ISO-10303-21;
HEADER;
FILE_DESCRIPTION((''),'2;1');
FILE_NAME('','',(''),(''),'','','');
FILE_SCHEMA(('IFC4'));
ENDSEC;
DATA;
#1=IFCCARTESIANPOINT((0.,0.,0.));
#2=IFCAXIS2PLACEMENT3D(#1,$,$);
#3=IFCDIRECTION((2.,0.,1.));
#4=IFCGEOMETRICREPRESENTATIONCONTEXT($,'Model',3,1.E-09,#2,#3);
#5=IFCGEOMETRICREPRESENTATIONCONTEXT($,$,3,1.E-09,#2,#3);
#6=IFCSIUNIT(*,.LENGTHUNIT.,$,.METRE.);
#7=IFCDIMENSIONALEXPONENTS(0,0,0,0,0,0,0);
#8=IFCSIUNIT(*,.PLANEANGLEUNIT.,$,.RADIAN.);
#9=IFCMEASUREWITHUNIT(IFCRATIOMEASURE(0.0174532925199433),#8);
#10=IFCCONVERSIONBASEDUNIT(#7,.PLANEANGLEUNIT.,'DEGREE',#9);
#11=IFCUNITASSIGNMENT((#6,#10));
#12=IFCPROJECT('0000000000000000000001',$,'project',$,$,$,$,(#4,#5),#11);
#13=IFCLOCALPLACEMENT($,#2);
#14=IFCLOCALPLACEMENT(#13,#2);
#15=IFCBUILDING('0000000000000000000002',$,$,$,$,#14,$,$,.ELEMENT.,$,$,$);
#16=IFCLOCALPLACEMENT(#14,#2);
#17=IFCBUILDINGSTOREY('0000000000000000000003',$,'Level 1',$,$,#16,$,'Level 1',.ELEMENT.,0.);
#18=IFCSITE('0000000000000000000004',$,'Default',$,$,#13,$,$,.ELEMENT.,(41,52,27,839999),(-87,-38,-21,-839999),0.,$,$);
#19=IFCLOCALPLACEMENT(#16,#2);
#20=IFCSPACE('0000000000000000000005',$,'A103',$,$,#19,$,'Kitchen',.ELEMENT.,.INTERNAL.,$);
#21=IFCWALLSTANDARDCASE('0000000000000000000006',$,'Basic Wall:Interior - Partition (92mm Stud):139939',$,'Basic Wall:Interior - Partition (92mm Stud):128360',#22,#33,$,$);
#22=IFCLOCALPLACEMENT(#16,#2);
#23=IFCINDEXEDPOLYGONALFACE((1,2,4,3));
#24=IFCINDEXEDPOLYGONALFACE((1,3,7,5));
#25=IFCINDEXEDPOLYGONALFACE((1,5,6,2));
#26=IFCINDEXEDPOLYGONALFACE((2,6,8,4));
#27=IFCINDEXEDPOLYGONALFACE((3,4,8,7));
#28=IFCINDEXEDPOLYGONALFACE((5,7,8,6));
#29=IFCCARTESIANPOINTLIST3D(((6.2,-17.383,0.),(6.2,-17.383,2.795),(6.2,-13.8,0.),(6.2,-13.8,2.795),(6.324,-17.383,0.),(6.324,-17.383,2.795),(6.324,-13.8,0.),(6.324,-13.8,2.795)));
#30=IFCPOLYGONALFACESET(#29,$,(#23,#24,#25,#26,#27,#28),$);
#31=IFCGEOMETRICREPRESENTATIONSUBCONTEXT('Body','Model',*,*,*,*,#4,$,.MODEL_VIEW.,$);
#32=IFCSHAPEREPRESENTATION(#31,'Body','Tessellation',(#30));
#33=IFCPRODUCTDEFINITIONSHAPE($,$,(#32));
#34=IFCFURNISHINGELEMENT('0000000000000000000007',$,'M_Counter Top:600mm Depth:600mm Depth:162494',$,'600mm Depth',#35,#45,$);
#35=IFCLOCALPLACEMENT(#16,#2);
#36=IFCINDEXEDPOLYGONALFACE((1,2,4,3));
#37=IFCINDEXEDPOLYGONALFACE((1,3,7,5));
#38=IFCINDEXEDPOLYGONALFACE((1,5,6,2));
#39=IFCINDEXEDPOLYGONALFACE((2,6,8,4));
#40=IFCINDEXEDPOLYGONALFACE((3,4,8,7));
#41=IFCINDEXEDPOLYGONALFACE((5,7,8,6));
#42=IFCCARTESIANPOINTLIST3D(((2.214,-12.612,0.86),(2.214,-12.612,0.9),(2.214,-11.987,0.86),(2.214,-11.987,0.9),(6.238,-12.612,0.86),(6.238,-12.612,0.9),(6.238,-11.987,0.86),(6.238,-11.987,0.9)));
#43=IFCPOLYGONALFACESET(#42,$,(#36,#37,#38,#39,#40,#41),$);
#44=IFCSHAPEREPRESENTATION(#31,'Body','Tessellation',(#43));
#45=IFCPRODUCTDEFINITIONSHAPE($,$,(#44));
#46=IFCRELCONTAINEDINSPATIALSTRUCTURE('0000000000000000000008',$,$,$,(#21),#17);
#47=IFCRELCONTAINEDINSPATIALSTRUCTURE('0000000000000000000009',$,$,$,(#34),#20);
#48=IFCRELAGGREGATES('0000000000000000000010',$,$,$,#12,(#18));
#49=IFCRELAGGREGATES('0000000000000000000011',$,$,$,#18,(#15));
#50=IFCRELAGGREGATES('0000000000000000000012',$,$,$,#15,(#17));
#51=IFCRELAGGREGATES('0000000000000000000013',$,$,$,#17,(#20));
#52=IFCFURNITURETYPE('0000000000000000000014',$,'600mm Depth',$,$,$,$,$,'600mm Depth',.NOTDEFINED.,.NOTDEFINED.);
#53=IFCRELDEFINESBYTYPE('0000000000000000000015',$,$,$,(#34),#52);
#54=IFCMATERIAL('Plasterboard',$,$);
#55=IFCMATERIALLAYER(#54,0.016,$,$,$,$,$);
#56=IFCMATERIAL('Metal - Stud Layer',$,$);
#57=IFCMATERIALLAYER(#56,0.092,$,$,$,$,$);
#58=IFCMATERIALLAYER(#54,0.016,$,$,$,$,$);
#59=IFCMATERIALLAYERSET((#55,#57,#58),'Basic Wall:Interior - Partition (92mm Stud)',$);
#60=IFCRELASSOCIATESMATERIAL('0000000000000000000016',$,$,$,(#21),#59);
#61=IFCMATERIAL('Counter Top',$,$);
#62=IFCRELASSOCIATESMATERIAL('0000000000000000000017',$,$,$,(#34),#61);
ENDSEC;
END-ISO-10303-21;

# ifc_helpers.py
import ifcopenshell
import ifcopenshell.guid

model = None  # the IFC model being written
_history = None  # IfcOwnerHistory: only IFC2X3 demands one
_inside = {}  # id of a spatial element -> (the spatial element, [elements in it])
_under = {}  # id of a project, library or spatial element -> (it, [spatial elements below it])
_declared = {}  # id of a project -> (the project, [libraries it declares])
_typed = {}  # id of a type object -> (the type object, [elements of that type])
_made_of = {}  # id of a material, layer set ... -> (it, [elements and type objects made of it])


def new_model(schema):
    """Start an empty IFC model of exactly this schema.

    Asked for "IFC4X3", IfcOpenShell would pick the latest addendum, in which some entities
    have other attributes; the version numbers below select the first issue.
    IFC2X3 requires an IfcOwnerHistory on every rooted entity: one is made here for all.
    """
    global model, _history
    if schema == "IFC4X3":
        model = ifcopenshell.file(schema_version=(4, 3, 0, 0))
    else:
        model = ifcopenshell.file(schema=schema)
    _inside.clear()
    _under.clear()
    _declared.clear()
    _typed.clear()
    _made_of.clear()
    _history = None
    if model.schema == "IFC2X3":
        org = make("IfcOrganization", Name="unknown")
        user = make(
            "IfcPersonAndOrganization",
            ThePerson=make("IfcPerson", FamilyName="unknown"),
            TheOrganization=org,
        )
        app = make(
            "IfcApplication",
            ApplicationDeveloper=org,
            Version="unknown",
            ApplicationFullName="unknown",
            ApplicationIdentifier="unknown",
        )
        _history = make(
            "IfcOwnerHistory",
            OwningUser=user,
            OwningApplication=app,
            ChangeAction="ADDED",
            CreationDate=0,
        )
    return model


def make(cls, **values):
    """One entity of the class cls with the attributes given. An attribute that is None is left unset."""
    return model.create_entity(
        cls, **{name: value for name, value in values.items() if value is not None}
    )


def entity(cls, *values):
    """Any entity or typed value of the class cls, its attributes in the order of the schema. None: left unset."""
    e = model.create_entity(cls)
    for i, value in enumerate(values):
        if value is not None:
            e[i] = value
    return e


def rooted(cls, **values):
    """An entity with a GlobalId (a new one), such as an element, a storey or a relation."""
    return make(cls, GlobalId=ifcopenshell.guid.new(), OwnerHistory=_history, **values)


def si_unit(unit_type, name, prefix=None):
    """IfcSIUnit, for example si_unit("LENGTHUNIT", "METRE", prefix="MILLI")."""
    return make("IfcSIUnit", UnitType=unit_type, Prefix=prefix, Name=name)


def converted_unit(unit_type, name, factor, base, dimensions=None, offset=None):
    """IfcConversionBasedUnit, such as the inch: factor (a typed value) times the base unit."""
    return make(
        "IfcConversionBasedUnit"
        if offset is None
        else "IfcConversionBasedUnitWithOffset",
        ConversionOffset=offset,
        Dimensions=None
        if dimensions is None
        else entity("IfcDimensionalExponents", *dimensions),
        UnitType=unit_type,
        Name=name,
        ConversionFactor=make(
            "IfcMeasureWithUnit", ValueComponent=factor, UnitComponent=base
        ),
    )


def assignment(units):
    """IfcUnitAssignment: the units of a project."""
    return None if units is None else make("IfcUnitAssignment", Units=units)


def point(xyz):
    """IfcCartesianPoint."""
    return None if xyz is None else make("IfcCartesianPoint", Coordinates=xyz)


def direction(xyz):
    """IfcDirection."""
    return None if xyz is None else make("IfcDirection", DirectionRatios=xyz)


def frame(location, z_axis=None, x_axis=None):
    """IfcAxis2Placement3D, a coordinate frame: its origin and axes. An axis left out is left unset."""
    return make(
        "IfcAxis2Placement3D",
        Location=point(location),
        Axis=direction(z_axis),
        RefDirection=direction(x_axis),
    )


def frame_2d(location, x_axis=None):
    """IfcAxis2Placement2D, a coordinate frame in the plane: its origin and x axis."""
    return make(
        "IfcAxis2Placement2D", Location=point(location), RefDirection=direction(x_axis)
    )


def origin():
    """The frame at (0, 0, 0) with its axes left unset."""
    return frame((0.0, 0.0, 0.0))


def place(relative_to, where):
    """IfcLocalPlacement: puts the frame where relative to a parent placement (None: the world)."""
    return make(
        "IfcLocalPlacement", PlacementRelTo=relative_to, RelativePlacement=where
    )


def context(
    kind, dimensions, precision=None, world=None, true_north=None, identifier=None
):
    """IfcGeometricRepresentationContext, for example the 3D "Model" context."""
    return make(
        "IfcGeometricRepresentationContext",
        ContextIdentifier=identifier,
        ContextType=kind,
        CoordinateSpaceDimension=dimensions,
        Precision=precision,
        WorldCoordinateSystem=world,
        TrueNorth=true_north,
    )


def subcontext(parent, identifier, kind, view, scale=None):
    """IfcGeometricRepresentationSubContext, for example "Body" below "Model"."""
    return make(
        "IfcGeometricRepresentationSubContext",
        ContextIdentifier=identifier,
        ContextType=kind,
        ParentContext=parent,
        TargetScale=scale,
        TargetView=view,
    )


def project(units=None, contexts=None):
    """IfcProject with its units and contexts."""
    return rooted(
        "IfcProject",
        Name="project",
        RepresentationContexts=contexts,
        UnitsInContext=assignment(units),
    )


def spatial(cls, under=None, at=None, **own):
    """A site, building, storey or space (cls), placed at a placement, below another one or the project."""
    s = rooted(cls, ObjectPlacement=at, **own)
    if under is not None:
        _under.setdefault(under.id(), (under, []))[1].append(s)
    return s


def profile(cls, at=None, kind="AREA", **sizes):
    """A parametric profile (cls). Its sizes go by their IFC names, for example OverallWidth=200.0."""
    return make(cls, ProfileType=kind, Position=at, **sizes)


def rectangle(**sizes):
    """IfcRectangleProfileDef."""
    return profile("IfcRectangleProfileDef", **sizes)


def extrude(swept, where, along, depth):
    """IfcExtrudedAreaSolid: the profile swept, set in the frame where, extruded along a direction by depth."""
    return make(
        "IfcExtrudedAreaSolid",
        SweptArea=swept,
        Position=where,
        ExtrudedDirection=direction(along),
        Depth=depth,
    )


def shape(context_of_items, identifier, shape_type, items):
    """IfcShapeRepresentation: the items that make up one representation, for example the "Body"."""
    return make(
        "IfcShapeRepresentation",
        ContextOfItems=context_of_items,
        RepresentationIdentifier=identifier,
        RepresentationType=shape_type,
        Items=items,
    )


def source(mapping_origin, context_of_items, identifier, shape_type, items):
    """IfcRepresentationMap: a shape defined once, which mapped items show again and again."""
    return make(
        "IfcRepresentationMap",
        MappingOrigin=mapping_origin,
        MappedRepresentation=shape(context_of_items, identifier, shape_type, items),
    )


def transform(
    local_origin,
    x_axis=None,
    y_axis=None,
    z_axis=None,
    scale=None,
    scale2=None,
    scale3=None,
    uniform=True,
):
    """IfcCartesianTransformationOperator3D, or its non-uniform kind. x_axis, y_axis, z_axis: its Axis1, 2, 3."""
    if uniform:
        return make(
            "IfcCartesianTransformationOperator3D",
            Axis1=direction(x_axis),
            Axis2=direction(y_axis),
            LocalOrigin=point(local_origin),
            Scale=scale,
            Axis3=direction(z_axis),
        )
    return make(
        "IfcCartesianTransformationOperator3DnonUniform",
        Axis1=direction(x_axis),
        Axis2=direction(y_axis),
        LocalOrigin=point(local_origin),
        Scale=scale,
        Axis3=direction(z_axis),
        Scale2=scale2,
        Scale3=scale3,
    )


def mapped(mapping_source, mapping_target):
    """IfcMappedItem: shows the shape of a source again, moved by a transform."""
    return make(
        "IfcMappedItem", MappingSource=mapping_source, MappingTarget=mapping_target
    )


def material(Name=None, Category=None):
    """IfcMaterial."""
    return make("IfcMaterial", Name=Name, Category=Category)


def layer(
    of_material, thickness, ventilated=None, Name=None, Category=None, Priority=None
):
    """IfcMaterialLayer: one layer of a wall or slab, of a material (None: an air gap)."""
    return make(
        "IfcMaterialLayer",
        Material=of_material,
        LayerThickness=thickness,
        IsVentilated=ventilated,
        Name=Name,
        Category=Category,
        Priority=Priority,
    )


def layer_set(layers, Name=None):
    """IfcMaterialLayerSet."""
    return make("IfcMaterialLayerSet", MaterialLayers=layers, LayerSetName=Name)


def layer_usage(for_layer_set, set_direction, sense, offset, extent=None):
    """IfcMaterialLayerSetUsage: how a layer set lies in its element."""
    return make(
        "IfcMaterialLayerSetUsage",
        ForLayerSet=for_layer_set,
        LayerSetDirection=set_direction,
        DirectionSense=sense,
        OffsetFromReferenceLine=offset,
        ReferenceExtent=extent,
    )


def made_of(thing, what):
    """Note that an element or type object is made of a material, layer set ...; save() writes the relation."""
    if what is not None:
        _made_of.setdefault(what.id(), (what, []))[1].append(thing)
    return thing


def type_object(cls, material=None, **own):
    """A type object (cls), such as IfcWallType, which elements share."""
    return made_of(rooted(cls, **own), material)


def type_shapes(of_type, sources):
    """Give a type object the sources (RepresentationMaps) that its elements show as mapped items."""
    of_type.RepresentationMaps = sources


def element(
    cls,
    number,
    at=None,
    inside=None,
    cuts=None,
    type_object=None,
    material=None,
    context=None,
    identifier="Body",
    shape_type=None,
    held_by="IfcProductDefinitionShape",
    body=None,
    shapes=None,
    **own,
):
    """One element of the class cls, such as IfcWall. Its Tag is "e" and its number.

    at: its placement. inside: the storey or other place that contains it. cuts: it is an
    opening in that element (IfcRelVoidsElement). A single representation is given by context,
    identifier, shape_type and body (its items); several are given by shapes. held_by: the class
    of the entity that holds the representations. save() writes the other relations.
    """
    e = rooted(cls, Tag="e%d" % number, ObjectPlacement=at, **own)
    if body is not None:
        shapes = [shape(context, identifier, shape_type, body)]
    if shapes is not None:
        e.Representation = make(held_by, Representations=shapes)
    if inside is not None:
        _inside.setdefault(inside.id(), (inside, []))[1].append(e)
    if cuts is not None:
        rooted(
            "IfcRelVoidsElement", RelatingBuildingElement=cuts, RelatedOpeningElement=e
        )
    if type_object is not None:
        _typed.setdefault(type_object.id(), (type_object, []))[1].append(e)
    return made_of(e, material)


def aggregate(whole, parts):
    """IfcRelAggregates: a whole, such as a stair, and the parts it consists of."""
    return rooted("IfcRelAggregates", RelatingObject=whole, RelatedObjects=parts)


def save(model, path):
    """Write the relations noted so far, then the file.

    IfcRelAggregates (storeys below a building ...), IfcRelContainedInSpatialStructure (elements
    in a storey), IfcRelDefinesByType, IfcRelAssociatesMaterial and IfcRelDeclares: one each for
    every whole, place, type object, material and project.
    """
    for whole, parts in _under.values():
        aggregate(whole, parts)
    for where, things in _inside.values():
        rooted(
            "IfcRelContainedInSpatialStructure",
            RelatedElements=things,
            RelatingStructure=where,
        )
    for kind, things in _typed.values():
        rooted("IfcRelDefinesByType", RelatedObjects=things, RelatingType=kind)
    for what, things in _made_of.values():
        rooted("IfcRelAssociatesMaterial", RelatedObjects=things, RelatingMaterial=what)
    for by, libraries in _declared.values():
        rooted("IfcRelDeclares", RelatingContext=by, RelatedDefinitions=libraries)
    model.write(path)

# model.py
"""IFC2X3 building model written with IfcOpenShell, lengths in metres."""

from ifc_helpers import new_model, entity, si_unit, converted_unit, direction, frame, frame_2d, origin, place, context, subcontext, project, spatial, rectangle, extrude, source, transform, mapped, material, layer, layer_set, layer_usage, type_object, type_shapes, element, save


model = new_model("IFC2X3")

# Units and contexts
model_context = context("Model", 3, precision=1e-09, world=origin(), true_north=direction((2.0, 0.0, 1.0)))
context_of_model = context(None, 3, precision=1e-09, world=origin(), true_north=direction((2.0, 0.0, 1.0)))
body_context = subcontext(model_context, "Body", "Model", "MODEL_VIEW")
ifc_project = project(units=[si_unit("LENGTHUNIT", "METRE"), converted_unit("PLANEANGLEUNIT", "DEGREE", entity("IfcRatioMeasure", 0.0174532925199433), si_unit("PLANEANGLEUNIT", "RADIAN"), dimensions=[0, 0, 0, 0, 0, 0, 0])], contexts=[model_context, context_of_model])

# Site, building, storey
site_placement = place(None, origin())
site = spatial("IfcSite", under=ifc_project, at=site_placement, Name="Default", CompositionType="ELEMENT", RefLatitude=(41, 52, 27, 839999), RefLongitude=(-87, -38, -21, -839999), RefElevation=0.0)
building_placement = place(site_placement, origin())
building = spatial("IfcBuilding", under=site, at=building_placement, CompositionType="ELEMENT")
storey_placement = place(building_placement, origin())
storey = spatial("IfcBuildingStorey", under=building, at=storey_placement, Name="Level 1", LongName="Level 1", CompositionType="ELEMENT", Elevation=0.0)

# Shared definitions
ifc_material_1 = material(Name="Metal - Stud Layer")
ifc_material_2 = material(Name="Plasterboard")

# Wall
ifc_layer_1 = layer(ifc_material_2, 0.016)
ifc_layer_2 = layer(ifc_material_1, 0.092)
ifc_layer_3 = layer(ifc_material_2, 0.016)
ifc_layer_set_1 = layer_set([ifc_layer_1, ifc_layer_2, ifc_layer_3], Name="Basic Wall:Interior - Partition (92mm Stud)")
ifc_layer_usage_1 = layer_usage(ifc_layer_set_1, "AXIS2", "NEGATIVE", 0.062)
wall_1_placement = place(storey_placement, frame((6.262, -13.8, 0.0), z_axis=(0.0, 0.0, 1.0), x_axis=(0.0, -1.0, 0.0)))
element("IfcWallStandardCase", 1, at=wall_1_placement, inside=storey, material=ifc_layer_usage_1, Name="Basic Wall:Interior - Partition (92mm Stud):139939", ObjectType="Basic Wall:Interior - Partition (92mm Stud):128360", context=body_context, shape_type="SweptSolid", body=[
    extrude(rectangle(XDim=3.583, YDim=0.124, at=frame_2d((1.7915, 0.0), x_axis=(-1.0, 0.0))), origin(), (0.0, 0.0, 1.0), 2.795),
])

# Shared definitions
space_1_placement = place(storey_placement, origin())
space_1 = spatial("IfcSpace", under=storey, at=space_1_placement, Name="A103", LongName="Kitchen", CompositionType="ELEMENT", InteriorOrExteriorSpace="INTERNAL")

# Furnishing element
ifc_material_3 = material(Name="Counter Top")
furniture_type_1 = type_object("IfcFurnitureType", Name="600mm Depth", ElementType="600mm Depth", AssemblyPlace="NOTDEFINED")
shared_shape_1 = source(origin(), body_context, "Body", "SweptSolid", [
    extrude(rectangle(XDim=4.024, YDim=0.625, at=frame_2d((0.0, 0.0), x_axis=(1.0, 0.0))), frame((0.8115, -0.3125, 0.86), z_axis=(0.0, 0.0, 1.0), x_axis=(-1.0, 0.0, 0.0)), (0.0, 0.0, 1.0), 0.04),
])
type_shapes(furniture_type_1, [shared_shape_1])
furnishing_1_placement = place(space_1_placement, frame((5.0375, -12.612, 0.0), z_axis=(0.0, 0.0, 1.0), x_axis=(-1.0, 0.0, 0.0)))
element("IfcFurnishingElement", 2, at=furnishing_1_placement, inside=space_1, type_object=furniture_type_1, material=ifc_material_3, Name="M_Counter Top:600mm Depth:600mm Depth:162494", ObjectType="600mm Depth", context=body_context, shape_type="MappedRepresentation", body=[
    mapped(shared_shape_1, transform((0.0, 0.0, 0.0), scale=1.0)),
])

save(model, "model.ifc")
